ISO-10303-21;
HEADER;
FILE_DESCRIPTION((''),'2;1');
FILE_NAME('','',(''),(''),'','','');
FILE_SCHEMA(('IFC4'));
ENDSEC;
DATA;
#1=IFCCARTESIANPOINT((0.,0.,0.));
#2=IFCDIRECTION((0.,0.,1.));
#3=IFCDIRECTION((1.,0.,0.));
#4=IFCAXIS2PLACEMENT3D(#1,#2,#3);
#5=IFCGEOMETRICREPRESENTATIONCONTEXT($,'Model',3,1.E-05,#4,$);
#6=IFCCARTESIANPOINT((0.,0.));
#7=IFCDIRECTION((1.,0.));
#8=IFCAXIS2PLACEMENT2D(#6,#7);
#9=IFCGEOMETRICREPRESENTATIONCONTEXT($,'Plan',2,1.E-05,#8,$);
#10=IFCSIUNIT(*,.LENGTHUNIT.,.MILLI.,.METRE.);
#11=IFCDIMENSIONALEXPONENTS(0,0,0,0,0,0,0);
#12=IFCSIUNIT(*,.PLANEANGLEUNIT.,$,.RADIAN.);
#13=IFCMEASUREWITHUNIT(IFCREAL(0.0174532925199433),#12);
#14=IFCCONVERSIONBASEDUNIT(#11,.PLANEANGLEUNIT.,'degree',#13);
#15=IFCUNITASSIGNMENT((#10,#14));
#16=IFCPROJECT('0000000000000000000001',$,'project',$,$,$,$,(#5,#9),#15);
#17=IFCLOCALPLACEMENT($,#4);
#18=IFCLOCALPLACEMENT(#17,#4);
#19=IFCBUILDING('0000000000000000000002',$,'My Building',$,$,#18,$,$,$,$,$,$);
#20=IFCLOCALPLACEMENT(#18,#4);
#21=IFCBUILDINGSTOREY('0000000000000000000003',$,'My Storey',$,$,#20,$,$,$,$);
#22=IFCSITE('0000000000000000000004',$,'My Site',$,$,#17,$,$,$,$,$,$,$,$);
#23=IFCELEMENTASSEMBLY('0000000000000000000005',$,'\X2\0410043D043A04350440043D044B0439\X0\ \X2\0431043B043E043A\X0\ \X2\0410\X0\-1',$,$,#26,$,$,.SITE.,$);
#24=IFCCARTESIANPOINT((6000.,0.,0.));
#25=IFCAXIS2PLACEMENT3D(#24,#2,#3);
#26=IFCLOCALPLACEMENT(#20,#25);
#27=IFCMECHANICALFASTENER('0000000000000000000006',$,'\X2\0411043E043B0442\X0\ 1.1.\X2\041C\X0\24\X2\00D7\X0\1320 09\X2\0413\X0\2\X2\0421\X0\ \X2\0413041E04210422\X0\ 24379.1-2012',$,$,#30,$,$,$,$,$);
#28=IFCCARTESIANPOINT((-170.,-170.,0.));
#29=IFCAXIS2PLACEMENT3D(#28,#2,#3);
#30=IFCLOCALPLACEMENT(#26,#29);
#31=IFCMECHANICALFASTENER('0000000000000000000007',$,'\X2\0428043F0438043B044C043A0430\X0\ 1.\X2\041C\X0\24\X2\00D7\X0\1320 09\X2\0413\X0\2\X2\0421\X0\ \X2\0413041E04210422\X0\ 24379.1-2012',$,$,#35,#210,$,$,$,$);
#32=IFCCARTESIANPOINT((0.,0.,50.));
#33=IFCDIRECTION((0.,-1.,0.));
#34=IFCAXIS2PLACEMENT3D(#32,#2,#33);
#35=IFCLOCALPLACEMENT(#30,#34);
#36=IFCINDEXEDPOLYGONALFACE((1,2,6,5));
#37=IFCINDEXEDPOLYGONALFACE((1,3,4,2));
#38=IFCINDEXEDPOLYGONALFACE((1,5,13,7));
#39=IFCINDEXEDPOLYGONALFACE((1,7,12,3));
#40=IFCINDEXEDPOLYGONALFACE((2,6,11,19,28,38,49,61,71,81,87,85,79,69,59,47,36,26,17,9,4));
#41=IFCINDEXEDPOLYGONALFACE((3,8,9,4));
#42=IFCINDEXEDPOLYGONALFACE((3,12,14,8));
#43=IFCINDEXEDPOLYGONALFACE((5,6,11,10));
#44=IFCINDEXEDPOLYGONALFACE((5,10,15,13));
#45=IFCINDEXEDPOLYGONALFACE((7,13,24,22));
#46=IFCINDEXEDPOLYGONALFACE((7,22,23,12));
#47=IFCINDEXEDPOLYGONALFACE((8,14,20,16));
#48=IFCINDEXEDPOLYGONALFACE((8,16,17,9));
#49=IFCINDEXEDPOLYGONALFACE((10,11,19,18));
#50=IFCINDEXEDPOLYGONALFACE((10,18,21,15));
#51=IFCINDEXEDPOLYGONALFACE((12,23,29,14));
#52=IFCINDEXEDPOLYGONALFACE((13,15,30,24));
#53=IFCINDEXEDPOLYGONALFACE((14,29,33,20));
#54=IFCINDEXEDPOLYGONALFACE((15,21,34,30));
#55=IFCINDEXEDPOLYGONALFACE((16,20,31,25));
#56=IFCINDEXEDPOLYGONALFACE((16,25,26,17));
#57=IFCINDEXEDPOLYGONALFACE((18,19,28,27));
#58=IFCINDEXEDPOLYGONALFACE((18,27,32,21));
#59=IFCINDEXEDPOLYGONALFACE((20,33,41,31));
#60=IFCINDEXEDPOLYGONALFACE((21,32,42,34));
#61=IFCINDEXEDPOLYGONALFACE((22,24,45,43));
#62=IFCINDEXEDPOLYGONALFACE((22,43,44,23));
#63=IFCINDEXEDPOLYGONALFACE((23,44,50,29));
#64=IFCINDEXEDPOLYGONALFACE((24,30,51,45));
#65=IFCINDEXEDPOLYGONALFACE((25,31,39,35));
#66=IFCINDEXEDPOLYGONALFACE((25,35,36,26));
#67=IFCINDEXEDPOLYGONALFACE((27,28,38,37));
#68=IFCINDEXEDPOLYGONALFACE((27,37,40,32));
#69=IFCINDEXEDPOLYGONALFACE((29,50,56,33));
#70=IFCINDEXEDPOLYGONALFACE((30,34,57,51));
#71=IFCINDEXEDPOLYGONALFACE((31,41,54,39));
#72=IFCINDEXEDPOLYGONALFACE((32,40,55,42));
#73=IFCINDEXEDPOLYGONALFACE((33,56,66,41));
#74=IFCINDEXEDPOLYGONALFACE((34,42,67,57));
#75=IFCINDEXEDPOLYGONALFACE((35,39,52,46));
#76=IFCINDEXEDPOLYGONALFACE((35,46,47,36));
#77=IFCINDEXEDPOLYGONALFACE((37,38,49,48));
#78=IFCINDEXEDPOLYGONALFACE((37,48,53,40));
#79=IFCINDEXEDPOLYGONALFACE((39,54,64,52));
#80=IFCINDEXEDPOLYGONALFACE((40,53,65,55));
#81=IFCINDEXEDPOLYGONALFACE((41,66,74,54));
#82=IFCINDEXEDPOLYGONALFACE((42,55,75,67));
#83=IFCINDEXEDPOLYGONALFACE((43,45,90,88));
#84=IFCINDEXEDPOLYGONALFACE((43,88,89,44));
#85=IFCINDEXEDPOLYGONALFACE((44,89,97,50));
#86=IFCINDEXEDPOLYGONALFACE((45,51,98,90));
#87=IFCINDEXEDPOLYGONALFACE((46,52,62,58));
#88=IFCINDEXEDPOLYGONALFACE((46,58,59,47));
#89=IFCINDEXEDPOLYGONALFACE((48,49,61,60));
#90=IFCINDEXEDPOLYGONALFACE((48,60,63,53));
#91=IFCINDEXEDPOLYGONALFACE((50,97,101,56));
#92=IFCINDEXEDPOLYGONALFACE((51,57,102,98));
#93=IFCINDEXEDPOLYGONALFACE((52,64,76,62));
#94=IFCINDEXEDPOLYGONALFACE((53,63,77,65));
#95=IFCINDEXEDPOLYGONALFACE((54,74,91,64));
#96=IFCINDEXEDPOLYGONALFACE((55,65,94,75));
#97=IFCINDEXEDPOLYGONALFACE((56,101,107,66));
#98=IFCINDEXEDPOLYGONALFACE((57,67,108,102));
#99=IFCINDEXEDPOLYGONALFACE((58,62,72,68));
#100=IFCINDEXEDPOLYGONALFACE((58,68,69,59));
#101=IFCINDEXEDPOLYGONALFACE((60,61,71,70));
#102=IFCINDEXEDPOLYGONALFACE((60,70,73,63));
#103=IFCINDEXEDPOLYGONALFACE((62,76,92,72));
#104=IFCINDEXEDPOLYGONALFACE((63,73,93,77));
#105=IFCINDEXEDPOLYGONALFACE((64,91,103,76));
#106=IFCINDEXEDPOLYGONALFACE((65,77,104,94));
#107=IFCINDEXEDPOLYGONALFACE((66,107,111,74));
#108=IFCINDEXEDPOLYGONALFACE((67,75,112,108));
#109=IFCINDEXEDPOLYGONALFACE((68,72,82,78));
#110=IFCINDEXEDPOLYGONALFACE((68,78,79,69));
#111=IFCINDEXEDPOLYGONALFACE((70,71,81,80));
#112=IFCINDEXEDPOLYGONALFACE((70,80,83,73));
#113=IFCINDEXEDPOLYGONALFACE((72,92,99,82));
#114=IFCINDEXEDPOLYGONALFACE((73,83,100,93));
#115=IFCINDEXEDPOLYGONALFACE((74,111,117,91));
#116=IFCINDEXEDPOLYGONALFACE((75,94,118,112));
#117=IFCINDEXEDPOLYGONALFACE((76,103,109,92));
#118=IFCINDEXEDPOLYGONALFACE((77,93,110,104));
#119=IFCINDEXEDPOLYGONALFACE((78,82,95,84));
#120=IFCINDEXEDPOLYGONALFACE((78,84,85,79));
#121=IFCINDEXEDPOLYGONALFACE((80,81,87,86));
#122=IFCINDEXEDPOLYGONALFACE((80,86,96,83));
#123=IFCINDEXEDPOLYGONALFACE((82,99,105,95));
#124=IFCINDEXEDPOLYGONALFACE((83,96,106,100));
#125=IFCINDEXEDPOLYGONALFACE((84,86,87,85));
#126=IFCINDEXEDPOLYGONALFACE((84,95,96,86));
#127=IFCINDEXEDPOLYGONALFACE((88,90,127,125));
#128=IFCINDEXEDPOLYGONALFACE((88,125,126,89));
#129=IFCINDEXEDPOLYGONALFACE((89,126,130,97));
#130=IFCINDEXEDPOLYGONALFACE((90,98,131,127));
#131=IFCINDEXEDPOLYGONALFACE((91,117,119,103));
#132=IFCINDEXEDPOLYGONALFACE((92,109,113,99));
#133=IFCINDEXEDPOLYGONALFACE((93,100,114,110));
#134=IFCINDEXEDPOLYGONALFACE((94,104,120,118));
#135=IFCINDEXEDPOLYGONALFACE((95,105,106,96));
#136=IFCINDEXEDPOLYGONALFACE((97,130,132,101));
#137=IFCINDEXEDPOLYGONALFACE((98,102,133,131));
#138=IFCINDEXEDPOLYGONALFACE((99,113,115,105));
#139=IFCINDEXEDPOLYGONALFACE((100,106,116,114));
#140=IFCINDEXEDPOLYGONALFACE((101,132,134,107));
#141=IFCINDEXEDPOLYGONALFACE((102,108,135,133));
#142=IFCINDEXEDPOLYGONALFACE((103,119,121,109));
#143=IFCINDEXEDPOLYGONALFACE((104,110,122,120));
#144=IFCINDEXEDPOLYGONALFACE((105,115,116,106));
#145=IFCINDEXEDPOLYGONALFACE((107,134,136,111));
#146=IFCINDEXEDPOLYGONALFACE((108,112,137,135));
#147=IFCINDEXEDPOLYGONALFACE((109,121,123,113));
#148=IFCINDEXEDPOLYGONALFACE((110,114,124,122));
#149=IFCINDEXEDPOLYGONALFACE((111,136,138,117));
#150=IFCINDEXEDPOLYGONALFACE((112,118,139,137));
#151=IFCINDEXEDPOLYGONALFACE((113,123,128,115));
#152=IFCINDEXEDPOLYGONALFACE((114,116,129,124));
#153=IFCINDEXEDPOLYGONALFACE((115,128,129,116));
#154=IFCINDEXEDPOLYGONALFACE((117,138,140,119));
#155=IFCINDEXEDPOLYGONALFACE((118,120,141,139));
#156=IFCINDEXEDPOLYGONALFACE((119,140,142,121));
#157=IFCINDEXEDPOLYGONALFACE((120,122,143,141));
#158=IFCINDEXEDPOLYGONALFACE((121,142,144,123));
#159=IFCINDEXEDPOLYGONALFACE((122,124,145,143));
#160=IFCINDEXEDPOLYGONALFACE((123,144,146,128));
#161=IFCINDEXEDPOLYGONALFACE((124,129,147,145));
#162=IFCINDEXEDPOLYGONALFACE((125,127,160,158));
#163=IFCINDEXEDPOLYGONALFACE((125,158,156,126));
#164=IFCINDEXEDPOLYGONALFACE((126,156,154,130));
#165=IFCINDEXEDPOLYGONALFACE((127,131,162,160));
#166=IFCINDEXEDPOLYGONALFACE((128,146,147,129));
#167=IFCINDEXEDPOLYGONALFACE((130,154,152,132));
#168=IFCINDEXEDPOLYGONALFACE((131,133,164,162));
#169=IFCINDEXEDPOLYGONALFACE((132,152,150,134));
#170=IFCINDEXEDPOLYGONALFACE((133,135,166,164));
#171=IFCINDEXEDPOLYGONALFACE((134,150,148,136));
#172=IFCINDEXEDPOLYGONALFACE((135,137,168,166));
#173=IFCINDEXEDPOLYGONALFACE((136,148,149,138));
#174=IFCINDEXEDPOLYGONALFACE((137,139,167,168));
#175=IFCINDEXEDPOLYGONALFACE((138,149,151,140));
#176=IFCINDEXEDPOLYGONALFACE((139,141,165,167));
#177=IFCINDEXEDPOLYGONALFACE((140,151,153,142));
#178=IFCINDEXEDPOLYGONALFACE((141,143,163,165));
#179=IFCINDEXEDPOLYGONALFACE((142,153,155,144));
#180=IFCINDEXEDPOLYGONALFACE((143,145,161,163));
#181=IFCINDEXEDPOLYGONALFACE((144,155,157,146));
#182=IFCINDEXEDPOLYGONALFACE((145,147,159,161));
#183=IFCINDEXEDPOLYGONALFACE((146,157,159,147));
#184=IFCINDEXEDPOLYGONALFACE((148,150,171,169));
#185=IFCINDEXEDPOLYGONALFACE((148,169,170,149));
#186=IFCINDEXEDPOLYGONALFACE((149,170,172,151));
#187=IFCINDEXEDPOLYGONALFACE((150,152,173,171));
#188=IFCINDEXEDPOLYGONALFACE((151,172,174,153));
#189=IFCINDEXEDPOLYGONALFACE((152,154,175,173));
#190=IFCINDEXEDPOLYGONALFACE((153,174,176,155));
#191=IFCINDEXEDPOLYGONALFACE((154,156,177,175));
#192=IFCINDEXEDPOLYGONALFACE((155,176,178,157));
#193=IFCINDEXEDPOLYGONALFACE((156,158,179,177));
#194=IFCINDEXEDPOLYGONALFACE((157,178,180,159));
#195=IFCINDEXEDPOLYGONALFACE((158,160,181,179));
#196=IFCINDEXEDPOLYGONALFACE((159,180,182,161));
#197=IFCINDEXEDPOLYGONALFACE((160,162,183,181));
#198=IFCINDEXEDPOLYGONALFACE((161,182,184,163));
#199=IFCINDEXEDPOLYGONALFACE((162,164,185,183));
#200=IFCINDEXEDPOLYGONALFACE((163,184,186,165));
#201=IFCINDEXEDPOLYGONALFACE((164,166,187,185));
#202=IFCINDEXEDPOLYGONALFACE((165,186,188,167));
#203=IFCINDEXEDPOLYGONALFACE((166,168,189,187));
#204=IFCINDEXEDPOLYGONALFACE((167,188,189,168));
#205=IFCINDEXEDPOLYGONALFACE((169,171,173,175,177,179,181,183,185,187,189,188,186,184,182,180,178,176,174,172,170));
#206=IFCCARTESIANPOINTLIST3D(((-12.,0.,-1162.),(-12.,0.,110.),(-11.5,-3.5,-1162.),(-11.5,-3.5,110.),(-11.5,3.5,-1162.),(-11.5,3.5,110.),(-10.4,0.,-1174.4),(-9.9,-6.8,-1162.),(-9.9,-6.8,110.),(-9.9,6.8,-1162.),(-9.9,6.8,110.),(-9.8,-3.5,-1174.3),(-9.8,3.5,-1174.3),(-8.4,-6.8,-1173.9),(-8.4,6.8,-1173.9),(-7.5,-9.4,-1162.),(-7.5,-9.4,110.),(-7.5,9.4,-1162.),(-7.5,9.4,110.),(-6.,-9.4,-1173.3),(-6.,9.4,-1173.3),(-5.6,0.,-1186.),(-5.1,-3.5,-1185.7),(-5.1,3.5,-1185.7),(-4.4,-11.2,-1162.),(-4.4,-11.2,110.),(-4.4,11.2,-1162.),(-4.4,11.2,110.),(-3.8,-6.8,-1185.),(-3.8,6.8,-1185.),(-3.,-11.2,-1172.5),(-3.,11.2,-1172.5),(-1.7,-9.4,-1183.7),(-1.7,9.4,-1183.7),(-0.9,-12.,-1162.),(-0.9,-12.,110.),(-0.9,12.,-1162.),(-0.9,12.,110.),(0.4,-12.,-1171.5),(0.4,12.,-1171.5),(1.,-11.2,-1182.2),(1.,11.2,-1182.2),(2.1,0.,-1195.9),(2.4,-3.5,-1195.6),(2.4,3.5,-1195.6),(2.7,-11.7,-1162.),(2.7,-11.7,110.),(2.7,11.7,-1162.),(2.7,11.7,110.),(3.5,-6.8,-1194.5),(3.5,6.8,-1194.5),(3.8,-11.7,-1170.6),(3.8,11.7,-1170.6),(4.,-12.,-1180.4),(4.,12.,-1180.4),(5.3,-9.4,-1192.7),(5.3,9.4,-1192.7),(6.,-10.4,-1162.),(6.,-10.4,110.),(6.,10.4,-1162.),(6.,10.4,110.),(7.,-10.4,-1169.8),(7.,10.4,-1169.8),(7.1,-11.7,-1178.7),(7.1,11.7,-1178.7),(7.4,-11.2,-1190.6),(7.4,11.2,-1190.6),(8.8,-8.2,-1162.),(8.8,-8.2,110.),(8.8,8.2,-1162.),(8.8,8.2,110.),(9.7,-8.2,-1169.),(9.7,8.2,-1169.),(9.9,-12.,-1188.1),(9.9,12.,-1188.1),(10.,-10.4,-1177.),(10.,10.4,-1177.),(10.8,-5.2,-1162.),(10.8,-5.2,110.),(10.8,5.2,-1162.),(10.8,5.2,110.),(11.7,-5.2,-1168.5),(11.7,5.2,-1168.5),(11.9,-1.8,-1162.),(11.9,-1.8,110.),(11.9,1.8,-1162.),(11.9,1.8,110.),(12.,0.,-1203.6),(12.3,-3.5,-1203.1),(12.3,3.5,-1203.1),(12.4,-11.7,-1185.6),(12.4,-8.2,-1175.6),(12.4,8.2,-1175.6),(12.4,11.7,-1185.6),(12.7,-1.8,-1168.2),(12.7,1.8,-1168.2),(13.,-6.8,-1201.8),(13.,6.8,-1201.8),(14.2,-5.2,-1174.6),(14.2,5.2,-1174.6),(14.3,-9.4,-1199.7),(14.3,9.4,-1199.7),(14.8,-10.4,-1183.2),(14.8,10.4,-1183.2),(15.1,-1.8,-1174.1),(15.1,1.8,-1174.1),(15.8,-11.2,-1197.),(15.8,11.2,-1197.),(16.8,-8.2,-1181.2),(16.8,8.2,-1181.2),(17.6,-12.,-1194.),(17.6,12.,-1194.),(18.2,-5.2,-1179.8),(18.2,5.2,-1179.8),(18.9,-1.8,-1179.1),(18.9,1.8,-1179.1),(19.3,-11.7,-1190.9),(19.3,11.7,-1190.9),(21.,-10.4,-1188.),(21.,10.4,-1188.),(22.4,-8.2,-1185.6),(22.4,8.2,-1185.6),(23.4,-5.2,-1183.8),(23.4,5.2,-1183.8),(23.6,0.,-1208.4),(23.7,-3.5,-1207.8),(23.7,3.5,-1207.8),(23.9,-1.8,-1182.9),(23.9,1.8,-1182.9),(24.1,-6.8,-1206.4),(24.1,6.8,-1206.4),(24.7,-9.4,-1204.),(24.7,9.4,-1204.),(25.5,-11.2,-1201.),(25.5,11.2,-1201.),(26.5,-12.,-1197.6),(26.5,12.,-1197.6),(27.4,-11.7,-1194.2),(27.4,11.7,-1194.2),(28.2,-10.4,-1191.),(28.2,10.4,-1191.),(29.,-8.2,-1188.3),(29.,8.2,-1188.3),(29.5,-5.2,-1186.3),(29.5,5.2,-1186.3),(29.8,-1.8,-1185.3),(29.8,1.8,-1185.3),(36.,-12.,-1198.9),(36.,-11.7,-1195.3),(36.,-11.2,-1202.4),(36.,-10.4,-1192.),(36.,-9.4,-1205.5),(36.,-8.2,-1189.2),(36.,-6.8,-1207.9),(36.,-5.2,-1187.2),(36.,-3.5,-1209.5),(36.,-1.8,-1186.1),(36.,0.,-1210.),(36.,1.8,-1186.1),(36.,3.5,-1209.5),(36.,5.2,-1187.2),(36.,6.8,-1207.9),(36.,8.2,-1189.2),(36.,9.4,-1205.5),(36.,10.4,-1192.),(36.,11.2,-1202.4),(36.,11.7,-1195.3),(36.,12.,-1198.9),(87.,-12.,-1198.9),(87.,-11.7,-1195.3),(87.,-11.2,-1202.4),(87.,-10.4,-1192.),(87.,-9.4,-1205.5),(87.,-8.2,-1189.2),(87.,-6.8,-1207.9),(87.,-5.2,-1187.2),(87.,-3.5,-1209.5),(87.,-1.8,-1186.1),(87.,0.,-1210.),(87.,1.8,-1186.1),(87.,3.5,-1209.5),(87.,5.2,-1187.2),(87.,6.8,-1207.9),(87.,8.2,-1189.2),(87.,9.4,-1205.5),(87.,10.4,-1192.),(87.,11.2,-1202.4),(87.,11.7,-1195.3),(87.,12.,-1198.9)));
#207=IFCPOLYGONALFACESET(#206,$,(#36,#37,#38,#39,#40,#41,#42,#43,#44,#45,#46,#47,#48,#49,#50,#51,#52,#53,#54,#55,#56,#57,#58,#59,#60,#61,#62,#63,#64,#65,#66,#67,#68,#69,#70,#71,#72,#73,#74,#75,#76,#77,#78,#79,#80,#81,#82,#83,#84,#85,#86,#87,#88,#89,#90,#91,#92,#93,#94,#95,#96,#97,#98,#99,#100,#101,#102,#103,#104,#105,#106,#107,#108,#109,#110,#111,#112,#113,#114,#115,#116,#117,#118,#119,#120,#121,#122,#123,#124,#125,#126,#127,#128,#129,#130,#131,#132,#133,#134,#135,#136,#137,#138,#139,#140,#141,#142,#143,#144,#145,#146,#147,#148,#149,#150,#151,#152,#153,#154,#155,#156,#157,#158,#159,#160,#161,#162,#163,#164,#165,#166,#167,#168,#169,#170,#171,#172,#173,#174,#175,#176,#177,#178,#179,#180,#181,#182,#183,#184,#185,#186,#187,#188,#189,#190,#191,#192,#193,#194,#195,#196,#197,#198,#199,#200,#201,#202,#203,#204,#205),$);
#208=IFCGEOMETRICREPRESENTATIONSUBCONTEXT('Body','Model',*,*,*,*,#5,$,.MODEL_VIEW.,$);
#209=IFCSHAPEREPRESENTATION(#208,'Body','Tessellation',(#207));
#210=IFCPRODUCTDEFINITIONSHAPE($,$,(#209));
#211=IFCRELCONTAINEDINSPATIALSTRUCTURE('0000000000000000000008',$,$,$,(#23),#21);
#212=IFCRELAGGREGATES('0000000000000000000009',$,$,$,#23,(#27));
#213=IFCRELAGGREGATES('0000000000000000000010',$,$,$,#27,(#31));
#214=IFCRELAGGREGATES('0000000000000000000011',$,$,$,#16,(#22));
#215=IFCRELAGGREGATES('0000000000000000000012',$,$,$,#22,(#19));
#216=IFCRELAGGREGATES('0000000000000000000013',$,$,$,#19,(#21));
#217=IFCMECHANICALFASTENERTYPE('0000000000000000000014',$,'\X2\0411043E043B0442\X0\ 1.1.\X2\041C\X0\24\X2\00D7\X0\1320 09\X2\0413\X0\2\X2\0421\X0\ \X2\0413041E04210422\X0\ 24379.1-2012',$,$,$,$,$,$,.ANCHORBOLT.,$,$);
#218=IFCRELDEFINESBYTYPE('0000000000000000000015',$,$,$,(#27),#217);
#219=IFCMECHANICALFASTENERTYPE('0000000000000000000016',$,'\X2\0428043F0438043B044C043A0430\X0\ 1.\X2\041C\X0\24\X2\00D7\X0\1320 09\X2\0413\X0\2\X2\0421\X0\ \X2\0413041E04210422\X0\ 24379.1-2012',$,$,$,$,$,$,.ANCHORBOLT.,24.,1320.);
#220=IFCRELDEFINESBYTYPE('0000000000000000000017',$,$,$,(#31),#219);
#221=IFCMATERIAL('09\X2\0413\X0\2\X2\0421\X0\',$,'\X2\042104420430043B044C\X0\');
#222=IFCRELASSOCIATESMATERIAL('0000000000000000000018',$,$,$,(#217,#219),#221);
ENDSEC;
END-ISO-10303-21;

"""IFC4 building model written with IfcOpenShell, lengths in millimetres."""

from ifc_helpers import new_model, entity, si_unit, converted_unit, frame, origin_with_axes, origin_2d_with_axis, place, context, subcontext, project, spatial, source, transform, mapped, material, type_object, type_shapes, element, aggregate, save


model = new_model("IFC4")

# Units and contexts
model_context = context("Model", 3, precision=1e-05, world=origin_with_axes())
plan_context = context("Plan", 2, precision=1e-05, world=origin_2d_with_axis())
body_context = subcontext(model_context, "Body", "Model", "MODEL_VIEW")
ifc_project = project(units=[si_unit("LENGTHUNIT", "METRE", prefix="MILLI"), converted_unit("PLANEANGLEUNIT", "degree", entity("IfcReal", 0.0174532925199433), si_unit("PLANEANGLEUNIT", "RADIAN"), dimensions=[0, 0, 0, 0, 0, 0, 0])], contexts=[model_context, plan_context])

# Site, building, storey
site_placement = place(None, origin_with_axes())
site = spatial("IfcSite", under=ifc_project, at=site_placement, Name="My Site")
building_placement = place(site_placement, origin_with_axes())
building = spatial("IfcBuilding", under=site, at=building_placement, Name="My Building")
storey_placement = place(building_placement, origin_with_axes())
storey = spatial("IfcBuildingStorey", under=building, at=storey_placement, Name="My Storey")

# Element assembly, mechanical fasteners
assembly_1_placement = place(storey_placement, frame((6000.0, 0.0, 0.0), z_axis=(0.0, 0.0, 1.0), x_axis=(1.0, 0.0, 0.0)))
assembly_1 = element("IfcElementAssembly", 1, at=assembly_1_placement, inside=storey, Name="Анкерный блок А-1", AssemblyPlace="SITE")
ifc_material_1 = material(Name="09Г2С", Category="Сталь")
mechanical_fastener_type_1 = type_object("IfcMechanicalFastenerType", Name="Болт 1.1.М24×1320 09Г2С ГОСТ 24379.1-2012", PredefinedType="ANCHORBOLT", material=ifc_material_1)
mechanical_fastener_1_placement = place(assembly_1_placement, frame((-170.0, -170.0, 0.0), z_axis=(0.0, 0.0, 1.0), x_axis=(1.0, 0.0, 0.0)))
mechanical_fastener_1 = element("IfcMechanicalFastener", 2, at=mechanical_fastener_1_placement, type_object=mechanical_fastener_type_1, Name="Болт 1.1.М24×1320 09Г2С ГОСТ 24379.1-2012")
mechanical_fastener_type_2 = type_object("IfcMechanicalFastenerType", Name="Шпилька 1.М24×1320 09Г2С ГОСТ 24379.1-2012", NominalDiameter=24.0, NominalLength=1320.0, PredefinedType="ANCHORBOLT", material=ifc_material_1)
shared_shape_1 = source(frame((0.0, 0.0, 110.0), z_axis=(0.0, 0.0, 1.0), x_axis=(1.0, 0.0, 0.0)), body_context, "Body", "AdvancedSweptSolid", [
    entity("IfcSweptDiskSolid", entity("IfcIndexedPolyCurve", entity("IfcCartesianPointList3D", [[0.0, 0.0, 0.0], [0.0, 0.0, -1272.0], [10.5, 0.0, -1297.5], [36.0, 0.0, -1308.0], [87.0, 0.0, -1308.0]]), [entity("IfcLineIndex", [1, 2]), entity("IfcArcIndex", [2, 3, 4]), entity("IfcLineIndex", [4, 5])]), 12.0),
])
type_shapes(mechanical_fastener_type_2, [shared_shape_1])
mechanical_fastener_2_placement = place(mechanical_fastener_1_placement, frame((0.0, 0.0, 50.0), z_axis=(0.0, 0.0, 1.0), x_axis=(0.0, -1.0, 0.0)))
mechanical_fastener_2 = element("IfcMechanicalFastener", 3, at=mechanical_fastener_2_placement, type_object=mechanical_fastener_type_2, Name="Шпилька 1.М24×1320 09Г2С ГОСТ 24379.1-2012", context=body_context, shape_type="MappedRepresentation", body=[
    mapped(shared_shape_1, transform((0.0, 0.0, 0.0), x_axis=(1.0, 0.0, 0.0), y_axis=(0.0, 1.0, 0.0), z_axis=(0.0, 0.0, 1.0), scale=1.0)),
])
aggregate(assembly_1, [mechanical_fastener_1])

aggregate(mechanical_fastener_1, [mechanical_fastener_2])

save(model, "model.ifc")
